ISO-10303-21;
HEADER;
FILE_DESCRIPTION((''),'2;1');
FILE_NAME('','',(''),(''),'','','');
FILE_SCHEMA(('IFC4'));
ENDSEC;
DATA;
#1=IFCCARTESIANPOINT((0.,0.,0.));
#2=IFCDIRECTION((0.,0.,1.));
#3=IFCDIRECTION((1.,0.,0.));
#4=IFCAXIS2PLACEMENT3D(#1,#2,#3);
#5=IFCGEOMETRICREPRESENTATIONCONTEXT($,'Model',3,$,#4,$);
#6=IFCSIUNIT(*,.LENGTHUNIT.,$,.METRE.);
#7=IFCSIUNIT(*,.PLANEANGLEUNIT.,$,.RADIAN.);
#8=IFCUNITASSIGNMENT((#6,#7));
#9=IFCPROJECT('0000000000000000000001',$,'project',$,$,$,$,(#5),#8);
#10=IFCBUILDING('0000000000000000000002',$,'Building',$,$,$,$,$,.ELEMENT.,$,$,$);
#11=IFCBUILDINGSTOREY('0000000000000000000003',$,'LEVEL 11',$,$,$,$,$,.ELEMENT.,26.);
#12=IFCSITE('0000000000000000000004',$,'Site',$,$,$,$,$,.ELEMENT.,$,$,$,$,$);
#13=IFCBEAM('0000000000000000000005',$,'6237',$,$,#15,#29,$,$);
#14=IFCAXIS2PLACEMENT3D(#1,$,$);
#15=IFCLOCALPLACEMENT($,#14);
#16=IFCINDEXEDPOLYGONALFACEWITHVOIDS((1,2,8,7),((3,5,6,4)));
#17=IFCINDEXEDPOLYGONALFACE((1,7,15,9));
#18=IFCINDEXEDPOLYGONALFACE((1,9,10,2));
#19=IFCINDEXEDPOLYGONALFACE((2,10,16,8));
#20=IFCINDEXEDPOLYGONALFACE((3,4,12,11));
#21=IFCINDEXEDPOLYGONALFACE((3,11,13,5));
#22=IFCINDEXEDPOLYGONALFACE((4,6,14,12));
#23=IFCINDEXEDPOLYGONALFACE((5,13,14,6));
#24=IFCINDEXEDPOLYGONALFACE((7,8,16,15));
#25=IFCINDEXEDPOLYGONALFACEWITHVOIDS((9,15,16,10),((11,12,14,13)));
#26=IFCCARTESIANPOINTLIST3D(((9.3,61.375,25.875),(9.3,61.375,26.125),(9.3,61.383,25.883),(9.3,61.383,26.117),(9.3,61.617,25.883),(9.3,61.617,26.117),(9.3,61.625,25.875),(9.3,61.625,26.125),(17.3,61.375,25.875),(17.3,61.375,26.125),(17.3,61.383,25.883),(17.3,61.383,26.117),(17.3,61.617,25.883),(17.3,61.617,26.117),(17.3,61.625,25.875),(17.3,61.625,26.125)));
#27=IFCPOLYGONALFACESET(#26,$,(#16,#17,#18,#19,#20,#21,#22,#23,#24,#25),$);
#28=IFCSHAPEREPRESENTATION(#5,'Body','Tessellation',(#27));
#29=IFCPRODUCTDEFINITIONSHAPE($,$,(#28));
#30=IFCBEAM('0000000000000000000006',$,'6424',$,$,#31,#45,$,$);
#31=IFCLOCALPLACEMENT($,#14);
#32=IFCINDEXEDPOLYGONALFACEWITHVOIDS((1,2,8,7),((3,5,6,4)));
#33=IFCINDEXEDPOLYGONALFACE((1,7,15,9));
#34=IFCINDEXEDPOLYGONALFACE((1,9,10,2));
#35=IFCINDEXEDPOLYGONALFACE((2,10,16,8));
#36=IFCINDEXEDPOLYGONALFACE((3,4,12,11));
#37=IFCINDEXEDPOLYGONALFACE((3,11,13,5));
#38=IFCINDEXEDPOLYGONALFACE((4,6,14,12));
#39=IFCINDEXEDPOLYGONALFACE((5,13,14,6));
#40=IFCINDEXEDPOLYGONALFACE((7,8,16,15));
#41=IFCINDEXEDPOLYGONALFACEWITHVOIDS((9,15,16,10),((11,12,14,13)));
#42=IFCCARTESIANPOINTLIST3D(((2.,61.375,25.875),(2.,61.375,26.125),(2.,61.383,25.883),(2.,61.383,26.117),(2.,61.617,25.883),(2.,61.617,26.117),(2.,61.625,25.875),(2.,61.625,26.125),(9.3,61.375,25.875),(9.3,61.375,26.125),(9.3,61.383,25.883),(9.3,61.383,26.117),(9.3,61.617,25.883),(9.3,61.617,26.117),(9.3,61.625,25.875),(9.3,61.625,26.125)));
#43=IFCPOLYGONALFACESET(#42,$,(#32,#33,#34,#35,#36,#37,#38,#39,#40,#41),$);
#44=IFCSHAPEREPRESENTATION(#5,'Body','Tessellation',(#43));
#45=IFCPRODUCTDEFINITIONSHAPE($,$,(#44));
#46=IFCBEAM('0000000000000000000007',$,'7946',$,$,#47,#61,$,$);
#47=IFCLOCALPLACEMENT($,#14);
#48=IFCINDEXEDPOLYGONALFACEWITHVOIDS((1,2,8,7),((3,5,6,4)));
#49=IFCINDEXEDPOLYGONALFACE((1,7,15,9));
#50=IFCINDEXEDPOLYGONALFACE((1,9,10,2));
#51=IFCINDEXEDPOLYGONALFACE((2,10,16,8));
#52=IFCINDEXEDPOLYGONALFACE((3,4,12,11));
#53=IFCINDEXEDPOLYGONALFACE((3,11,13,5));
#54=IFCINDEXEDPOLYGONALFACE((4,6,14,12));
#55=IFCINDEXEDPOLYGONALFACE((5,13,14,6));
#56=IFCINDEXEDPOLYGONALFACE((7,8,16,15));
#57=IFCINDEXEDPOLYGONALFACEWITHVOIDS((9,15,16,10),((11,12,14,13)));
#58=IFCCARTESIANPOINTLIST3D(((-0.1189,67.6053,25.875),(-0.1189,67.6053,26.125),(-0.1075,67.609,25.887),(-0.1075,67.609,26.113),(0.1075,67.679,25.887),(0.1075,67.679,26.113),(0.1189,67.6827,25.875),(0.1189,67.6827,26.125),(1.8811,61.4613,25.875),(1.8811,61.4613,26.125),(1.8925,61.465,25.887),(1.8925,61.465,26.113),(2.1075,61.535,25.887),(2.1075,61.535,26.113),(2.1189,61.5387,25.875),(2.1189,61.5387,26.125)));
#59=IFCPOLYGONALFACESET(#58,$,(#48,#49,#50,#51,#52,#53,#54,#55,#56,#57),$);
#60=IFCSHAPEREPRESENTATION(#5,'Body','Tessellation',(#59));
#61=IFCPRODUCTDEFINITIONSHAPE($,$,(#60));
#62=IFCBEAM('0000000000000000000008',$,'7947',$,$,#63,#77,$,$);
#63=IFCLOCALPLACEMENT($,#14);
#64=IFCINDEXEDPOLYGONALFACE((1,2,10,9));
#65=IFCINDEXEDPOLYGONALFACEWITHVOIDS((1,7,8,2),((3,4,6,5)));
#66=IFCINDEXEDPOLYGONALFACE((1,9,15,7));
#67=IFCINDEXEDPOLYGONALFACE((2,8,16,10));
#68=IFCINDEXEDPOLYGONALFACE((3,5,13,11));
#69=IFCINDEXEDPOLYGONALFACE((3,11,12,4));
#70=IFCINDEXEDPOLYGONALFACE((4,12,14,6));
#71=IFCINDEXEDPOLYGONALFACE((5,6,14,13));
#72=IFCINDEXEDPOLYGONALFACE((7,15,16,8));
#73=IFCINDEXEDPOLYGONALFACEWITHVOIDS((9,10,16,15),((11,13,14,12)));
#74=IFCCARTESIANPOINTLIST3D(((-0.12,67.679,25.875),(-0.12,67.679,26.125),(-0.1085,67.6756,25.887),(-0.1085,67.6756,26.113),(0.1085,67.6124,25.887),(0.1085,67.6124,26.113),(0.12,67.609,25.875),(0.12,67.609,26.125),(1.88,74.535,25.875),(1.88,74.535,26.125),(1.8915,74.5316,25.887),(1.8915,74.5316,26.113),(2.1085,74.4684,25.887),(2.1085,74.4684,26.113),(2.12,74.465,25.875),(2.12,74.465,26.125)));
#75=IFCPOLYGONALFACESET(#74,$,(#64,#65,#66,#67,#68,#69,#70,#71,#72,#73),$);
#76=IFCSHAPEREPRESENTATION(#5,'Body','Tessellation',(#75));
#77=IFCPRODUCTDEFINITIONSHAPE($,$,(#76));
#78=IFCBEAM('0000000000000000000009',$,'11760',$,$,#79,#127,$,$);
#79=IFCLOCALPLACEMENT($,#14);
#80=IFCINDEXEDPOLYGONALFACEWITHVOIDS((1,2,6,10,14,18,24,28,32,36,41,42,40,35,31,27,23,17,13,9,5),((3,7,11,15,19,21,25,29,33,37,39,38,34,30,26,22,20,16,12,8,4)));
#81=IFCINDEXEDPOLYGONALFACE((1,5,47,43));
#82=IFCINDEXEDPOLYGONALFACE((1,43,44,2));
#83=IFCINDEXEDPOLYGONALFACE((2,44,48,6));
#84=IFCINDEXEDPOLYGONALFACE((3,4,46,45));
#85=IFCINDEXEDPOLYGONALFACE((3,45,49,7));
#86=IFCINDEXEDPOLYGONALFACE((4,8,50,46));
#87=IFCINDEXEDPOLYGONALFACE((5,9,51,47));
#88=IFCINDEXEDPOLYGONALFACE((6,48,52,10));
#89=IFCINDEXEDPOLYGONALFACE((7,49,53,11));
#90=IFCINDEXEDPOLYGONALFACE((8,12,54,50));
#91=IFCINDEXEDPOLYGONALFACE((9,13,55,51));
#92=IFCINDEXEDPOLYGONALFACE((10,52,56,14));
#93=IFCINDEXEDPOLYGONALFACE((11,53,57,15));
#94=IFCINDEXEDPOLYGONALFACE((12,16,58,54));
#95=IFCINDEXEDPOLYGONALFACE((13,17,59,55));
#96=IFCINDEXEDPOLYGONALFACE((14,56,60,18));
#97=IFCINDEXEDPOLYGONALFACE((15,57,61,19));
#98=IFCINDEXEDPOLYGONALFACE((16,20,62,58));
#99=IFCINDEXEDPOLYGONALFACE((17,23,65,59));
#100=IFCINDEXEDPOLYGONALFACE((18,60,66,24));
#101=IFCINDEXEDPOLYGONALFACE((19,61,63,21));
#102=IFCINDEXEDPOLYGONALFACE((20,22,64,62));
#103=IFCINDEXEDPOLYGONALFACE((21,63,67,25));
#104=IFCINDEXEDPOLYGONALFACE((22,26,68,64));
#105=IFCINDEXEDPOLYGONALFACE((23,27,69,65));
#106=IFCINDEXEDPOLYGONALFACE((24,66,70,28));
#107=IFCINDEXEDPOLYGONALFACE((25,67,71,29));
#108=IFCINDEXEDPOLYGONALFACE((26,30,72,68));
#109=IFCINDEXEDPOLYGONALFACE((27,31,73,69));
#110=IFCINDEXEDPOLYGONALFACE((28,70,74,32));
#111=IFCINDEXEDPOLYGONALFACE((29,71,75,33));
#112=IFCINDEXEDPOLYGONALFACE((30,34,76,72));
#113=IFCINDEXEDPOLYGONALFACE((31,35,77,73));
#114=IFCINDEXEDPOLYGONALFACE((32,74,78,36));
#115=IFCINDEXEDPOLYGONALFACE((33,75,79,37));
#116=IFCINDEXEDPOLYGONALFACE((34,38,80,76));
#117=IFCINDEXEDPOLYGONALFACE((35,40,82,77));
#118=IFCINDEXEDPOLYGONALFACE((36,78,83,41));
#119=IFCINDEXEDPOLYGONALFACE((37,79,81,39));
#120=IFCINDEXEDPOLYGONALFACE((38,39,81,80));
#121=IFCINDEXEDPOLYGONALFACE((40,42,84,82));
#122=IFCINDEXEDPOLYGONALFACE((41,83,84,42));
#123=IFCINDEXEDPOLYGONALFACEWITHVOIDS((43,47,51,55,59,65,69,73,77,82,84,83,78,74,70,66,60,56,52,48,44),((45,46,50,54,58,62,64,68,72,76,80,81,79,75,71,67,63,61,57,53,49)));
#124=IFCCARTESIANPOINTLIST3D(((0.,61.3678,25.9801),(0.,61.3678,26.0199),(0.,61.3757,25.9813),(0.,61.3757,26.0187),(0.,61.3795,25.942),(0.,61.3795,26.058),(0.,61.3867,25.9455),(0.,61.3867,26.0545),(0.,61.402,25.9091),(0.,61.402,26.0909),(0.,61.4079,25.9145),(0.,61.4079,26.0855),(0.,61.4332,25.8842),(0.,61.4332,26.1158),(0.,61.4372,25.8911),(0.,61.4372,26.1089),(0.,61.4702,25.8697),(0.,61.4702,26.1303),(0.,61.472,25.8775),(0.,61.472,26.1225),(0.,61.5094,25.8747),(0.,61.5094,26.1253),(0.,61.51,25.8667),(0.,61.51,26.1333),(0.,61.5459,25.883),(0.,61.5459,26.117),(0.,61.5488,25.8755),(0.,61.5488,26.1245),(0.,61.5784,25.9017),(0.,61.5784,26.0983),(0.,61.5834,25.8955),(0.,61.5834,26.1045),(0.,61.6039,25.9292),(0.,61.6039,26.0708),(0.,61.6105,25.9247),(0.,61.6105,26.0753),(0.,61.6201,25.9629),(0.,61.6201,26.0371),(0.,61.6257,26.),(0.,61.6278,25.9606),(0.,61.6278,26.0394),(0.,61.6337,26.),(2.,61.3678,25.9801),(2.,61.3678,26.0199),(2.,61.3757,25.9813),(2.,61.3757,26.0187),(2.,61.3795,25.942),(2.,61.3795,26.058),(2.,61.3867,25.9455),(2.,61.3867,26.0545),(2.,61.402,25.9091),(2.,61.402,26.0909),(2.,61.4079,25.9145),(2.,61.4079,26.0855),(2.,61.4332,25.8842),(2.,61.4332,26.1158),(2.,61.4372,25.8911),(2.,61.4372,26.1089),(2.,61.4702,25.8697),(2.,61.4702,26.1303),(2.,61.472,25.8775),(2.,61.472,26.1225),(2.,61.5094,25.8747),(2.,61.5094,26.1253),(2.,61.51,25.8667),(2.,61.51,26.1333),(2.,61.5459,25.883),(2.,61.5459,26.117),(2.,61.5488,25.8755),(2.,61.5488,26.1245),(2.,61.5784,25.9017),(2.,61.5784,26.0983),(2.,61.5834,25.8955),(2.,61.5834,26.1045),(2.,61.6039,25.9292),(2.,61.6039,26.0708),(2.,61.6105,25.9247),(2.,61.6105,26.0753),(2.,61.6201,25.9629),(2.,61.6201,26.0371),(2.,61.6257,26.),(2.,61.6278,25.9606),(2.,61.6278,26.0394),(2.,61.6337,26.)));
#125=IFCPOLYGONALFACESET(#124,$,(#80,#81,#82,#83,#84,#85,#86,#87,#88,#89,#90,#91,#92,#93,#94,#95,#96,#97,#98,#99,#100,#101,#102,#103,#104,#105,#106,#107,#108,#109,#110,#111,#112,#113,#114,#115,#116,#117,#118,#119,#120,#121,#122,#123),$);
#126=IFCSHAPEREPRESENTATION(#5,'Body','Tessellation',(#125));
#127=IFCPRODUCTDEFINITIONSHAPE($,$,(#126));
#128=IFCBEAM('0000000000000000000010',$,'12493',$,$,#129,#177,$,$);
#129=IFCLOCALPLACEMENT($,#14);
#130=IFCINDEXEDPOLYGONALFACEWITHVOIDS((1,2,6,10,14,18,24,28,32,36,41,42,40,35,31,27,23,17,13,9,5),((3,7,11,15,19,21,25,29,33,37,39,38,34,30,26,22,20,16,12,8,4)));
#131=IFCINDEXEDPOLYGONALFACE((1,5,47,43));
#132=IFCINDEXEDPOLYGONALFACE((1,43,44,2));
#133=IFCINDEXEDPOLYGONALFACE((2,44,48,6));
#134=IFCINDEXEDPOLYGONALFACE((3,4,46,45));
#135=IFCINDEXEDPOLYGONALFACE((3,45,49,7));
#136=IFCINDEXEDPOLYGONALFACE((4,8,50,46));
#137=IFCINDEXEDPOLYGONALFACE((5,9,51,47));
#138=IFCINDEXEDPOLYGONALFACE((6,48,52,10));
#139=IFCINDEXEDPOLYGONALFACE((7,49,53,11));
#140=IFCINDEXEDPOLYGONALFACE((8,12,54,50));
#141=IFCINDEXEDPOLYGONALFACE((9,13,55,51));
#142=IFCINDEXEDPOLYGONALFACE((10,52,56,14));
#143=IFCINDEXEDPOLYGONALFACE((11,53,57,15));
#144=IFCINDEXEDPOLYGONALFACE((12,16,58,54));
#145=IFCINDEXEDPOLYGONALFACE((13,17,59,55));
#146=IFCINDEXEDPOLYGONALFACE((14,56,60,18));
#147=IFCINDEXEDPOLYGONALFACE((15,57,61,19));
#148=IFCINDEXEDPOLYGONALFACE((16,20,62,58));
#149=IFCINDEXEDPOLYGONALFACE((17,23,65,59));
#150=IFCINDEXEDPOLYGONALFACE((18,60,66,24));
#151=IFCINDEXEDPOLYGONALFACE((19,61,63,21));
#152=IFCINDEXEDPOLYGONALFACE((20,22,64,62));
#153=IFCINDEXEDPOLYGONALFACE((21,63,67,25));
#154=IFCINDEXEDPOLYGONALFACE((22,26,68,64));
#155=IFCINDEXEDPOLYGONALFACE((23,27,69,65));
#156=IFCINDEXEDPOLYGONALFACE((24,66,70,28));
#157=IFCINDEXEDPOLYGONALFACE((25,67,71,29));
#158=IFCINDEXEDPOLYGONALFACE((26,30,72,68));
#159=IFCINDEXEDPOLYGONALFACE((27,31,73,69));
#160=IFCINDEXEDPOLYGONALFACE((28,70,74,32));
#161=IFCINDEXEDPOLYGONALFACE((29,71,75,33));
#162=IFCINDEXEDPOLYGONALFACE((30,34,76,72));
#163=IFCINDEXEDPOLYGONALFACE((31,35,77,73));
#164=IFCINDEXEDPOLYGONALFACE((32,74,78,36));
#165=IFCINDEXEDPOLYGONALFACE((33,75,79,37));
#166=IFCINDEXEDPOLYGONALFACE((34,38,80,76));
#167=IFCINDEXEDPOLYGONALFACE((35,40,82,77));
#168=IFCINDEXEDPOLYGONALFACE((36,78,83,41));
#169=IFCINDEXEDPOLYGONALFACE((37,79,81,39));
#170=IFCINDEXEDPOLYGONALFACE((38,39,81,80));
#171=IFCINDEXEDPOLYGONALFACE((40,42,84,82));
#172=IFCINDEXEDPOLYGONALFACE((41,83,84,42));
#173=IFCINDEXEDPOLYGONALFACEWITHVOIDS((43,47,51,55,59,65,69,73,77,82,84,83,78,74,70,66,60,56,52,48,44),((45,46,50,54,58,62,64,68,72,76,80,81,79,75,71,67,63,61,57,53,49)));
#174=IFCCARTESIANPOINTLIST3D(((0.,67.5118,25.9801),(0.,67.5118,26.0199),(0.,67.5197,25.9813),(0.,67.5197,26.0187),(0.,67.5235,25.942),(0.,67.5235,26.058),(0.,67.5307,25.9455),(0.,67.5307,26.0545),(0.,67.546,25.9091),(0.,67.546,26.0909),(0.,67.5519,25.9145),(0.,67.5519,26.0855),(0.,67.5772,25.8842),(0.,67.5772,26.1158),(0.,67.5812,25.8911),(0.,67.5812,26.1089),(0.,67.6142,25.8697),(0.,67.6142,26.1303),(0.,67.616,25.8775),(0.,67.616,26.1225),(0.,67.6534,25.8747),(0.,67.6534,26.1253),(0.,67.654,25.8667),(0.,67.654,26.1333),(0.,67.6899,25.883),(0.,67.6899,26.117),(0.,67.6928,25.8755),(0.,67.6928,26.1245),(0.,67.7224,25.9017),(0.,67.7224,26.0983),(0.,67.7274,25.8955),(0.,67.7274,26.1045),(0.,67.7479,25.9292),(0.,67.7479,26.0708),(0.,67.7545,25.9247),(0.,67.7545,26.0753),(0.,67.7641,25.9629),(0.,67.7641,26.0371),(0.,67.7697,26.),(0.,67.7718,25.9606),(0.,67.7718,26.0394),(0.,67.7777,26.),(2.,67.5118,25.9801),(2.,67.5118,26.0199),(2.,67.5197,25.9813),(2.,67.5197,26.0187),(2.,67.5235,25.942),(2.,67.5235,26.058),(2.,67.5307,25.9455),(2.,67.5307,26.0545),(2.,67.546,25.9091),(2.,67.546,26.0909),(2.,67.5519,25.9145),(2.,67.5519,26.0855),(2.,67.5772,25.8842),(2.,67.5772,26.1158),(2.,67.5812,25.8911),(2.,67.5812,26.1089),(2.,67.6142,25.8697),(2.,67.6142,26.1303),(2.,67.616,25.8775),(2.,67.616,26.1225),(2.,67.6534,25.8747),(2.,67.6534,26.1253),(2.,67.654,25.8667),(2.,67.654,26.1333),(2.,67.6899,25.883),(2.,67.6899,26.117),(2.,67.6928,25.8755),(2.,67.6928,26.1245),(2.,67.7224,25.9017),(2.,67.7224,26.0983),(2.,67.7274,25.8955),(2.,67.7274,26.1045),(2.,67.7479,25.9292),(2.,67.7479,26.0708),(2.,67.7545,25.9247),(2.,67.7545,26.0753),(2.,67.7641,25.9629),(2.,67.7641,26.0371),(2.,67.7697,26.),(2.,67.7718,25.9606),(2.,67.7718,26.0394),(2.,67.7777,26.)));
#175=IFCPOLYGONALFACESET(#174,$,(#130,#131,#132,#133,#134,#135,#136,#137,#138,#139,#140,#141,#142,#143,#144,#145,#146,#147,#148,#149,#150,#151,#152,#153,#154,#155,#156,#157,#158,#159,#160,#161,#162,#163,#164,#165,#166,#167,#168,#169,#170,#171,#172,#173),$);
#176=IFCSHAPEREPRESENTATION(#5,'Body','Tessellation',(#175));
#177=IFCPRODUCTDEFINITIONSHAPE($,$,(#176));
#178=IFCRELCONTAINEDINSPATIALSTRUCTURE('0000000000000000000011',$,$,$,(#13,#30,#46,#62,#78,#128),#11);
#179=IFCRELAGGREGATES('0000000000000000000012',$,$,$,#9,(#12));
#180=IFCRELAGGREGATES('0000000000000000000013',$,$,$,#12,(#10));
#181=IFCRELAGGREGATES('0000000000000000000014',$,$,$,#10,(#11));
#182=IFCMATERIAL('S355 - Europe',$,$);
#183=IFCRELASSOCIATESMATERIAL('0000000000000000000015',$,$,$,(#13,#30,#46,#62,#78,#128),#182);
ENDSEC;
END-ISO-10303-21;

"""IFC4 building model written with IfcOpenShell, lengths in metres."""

from ifc_helpers import new_model, si_unit, frame, origin_with_axes, origin_2d_with_axis, place, context, project, spatial, hollow_rectangle, hollow_circle, extrude, material, material_profile, profile_set, profile_usage, element, save


model = new_model("IFC4")

# Units and contexts
model_context = context("Model", 3, world=origin_with_axes())
ifc_project = project(units=[si_unit("LENGTHUNIT", "METRE"), si_unit("PLANEANGLEUNIT", "RADIAN")], contexts=[model_context])

# Site, building, storey
site = spatial("IfcSite", under=ifc_project, Name="Site", CompositionType="ELEMENT")
building = spatial("IfcBuilding", under=site, Name="Building", CompositionType="ELEMENT")
storey = spatial("IfcBuildingStorey", under=building, Name="LEVEL 11", CompositionType="ELEMENT", Elevation=26.0)

# Shared definitions
ifc_material = material(Name="S355 - Europe")

# Beams
ifc_material_profile_1 = material_profile(ifc_material, hollow_rectangle(XDim=0.25, YDim=0.25, WallThickness=0.008, at=origin_2d_with_axis()))
ifc_profile_set_1 = profile_set([ifc_material_profile_1])
ifc_profile_usage_1 = profile_usage(ifc_profile_set_1, cardinal=10)
beam_1_placement = place(None, frame((9.3, 61.5, 26.0), z_axis=(1.0, 0.0, 0.0), x_axis=(0.0, 1.0, 0.0)))
element("IfcBeam", 1, at=beam_1_placement, inside=storey, material=ifc_profile_usage_1, Name="6237", context=model_context, shape_type="SweptSolid", body=[
    extrude(hollow_rectangle(XDim=0.25, YDim=0.25, WallThickness=0.008, at=origin_2d_with_axis()), origin_with_axes(), (0.0, 0.0, 1.0), 8.0),
])
ifc_material_profile_2 = material_profile(ifc_material, hollow_rectangle(XDim=0.25, YDim=0.25, WallThickness=0.008, at=origin_2d_with_axis()))
ifc_profile_set_2 = profile_set([ifc_material_profile_2])
ifc_profile_usage_2 = profile_usage(ifc_profile_set_2, cardinal=10)
beam_2_placement = place(None, frame((9.3, 61.5, 26.0), z_axis=(-1.0, 0.0, 0.0), x_axis=(0.0, -1.0, 0.0)))
element("IfcBeam", 2, at=beam_2_placement, inside=storey, material=ifc_profile_usage_2, Name="6424", context=model_context, shape_type="SweptSolid", body=[
    extrude(hollow_rectangle(XDim=0.25, YDim=0.25, WallThickness=0.008, at=origin_2d_with_axis()), origin_with_axes(), (0.0, 0.0, 1.0), 7.3),
])
ifc_material_profile_3 = material_profile(ifc_material, hollow_rectangle(XDim=0.25, YDim=0.25, WallThickness=0.012, at=origin_2d_with_axis()))
ifc_profile_set_3 = profile_set([ifc_material_profile_3])
ifc_profile_usage_3 = profile_usage(ifc_profile_set_3, cardinal=10)
beam_3_placement = place(None, frame((2.0, 61.5, 26.0), z_axis=(-0.309534, 0.950888, 0.0), x_axis=(-0.950888, -0.309534, 0.0)))
element("IfcBeam", 3, at=beam_3_placement, inside=storey, material=ifc_profile_usage_3, Name="7946", context=model_context, shape_type="SweptSolid", body=[
    extrude(hollow_rectangle(XDim=0.25, YDim=0.25, WallThickness=0.012, at=origin_2d_with_axis()), origin_with_axes(), (0.0, 0.0, 1.0), 6.4613),
])
ifc_material_profile_4 = material_profile(ifc_material, hollow_rectangle(XDim=0.25, YDim=0.25, WallThickness=0.012, at=origin_2d_with_axis()))
ifc_profile_set_4 = profile_set([ifc_material_profile_4])
ifc_profile_usage_4 = profile_usage(ifc_profile_set_4, cardinal=10)
beam_4_placement = place(None, frame((0.0, 67.644, 26.0), z_axis=(0.280043, 0.959987, 0.0), x_axis=(-0.959987, 0.280043, 0.0)))
element("IfcBeam", 4, at=beam_4_placement, inside=storey, material=ifc_profile_usage_4, Name="7947", context=model_context, shape_type="SweptSolid", body=[
    extrude(hollow_rectangle(XDim=0.25, YDim=0.25, WallThickness=0.012, at=origin_2d_with_axis()), origin_with_axes(), (0.0, 0.0, 1.0), 7.1418),
])
ifc_material_profile_5 = material_profile(ifc_material, hollow_circle(Radius=0.1337, WallThickness=0.008, at=origin_2d_with_axis()))
ifc_profile_set_5 = profile_set([ifc_material_profile_5])
ifc_profile_usage_5 = profile_usage(ifc_profile_set_5, cardinal=10)
beam_5_placement = place(None, frame((0.0, 61.5, 26.0), z_axis=(1.0, 0.0, 0.0), x_axis=(0.0, 1.0, 0.0)))
element("IfcBeam", 5, at=beam_5_placement, inside=storey, material=ifc_profile_usage_5, Name="11760", context=model_context, shape_type="SweptSolid", body=[
    extrude(hollow_circle(Radius=0.1337, WallThickness=0.008, at=origin_2d_with_axis()), origin_with_axes(), (0.0, 0.0, 1.0), 2.0),
])
ifc_material_profile_6 = material_profile(ifc_material, hollow_circle(Radius=0.1337, WallThickness=0.008, at=origin_2d_with_axis()))
ifc_profile_set_6 = profile_set([ifc_material_profile_6])
ifc_profile_usage_6 = profile_usage(ifc_profile_set_6, cardinal=10)
beam_6_placement = place(None, frame((0.0, 67.644, 26.0), z_axis=(1.0, 0.0, 0.0), x_axis=(0.0, 1.0, 0.0)))
element("IfcBeam", 6, at=beam_6_placement, inside=storey, material=ifc_profile_usage_6, Name="12493", context=model_context, shape_type="SweptSolid", body=[
    extrude(hollow_circle(Radius=0.1337, WallThickness=0.008, at=origin_2d_with_axis()), origin_with_axes(), (0.0, 0.0, 1.0), 2.0),
])

save(model, "model.ifc")
